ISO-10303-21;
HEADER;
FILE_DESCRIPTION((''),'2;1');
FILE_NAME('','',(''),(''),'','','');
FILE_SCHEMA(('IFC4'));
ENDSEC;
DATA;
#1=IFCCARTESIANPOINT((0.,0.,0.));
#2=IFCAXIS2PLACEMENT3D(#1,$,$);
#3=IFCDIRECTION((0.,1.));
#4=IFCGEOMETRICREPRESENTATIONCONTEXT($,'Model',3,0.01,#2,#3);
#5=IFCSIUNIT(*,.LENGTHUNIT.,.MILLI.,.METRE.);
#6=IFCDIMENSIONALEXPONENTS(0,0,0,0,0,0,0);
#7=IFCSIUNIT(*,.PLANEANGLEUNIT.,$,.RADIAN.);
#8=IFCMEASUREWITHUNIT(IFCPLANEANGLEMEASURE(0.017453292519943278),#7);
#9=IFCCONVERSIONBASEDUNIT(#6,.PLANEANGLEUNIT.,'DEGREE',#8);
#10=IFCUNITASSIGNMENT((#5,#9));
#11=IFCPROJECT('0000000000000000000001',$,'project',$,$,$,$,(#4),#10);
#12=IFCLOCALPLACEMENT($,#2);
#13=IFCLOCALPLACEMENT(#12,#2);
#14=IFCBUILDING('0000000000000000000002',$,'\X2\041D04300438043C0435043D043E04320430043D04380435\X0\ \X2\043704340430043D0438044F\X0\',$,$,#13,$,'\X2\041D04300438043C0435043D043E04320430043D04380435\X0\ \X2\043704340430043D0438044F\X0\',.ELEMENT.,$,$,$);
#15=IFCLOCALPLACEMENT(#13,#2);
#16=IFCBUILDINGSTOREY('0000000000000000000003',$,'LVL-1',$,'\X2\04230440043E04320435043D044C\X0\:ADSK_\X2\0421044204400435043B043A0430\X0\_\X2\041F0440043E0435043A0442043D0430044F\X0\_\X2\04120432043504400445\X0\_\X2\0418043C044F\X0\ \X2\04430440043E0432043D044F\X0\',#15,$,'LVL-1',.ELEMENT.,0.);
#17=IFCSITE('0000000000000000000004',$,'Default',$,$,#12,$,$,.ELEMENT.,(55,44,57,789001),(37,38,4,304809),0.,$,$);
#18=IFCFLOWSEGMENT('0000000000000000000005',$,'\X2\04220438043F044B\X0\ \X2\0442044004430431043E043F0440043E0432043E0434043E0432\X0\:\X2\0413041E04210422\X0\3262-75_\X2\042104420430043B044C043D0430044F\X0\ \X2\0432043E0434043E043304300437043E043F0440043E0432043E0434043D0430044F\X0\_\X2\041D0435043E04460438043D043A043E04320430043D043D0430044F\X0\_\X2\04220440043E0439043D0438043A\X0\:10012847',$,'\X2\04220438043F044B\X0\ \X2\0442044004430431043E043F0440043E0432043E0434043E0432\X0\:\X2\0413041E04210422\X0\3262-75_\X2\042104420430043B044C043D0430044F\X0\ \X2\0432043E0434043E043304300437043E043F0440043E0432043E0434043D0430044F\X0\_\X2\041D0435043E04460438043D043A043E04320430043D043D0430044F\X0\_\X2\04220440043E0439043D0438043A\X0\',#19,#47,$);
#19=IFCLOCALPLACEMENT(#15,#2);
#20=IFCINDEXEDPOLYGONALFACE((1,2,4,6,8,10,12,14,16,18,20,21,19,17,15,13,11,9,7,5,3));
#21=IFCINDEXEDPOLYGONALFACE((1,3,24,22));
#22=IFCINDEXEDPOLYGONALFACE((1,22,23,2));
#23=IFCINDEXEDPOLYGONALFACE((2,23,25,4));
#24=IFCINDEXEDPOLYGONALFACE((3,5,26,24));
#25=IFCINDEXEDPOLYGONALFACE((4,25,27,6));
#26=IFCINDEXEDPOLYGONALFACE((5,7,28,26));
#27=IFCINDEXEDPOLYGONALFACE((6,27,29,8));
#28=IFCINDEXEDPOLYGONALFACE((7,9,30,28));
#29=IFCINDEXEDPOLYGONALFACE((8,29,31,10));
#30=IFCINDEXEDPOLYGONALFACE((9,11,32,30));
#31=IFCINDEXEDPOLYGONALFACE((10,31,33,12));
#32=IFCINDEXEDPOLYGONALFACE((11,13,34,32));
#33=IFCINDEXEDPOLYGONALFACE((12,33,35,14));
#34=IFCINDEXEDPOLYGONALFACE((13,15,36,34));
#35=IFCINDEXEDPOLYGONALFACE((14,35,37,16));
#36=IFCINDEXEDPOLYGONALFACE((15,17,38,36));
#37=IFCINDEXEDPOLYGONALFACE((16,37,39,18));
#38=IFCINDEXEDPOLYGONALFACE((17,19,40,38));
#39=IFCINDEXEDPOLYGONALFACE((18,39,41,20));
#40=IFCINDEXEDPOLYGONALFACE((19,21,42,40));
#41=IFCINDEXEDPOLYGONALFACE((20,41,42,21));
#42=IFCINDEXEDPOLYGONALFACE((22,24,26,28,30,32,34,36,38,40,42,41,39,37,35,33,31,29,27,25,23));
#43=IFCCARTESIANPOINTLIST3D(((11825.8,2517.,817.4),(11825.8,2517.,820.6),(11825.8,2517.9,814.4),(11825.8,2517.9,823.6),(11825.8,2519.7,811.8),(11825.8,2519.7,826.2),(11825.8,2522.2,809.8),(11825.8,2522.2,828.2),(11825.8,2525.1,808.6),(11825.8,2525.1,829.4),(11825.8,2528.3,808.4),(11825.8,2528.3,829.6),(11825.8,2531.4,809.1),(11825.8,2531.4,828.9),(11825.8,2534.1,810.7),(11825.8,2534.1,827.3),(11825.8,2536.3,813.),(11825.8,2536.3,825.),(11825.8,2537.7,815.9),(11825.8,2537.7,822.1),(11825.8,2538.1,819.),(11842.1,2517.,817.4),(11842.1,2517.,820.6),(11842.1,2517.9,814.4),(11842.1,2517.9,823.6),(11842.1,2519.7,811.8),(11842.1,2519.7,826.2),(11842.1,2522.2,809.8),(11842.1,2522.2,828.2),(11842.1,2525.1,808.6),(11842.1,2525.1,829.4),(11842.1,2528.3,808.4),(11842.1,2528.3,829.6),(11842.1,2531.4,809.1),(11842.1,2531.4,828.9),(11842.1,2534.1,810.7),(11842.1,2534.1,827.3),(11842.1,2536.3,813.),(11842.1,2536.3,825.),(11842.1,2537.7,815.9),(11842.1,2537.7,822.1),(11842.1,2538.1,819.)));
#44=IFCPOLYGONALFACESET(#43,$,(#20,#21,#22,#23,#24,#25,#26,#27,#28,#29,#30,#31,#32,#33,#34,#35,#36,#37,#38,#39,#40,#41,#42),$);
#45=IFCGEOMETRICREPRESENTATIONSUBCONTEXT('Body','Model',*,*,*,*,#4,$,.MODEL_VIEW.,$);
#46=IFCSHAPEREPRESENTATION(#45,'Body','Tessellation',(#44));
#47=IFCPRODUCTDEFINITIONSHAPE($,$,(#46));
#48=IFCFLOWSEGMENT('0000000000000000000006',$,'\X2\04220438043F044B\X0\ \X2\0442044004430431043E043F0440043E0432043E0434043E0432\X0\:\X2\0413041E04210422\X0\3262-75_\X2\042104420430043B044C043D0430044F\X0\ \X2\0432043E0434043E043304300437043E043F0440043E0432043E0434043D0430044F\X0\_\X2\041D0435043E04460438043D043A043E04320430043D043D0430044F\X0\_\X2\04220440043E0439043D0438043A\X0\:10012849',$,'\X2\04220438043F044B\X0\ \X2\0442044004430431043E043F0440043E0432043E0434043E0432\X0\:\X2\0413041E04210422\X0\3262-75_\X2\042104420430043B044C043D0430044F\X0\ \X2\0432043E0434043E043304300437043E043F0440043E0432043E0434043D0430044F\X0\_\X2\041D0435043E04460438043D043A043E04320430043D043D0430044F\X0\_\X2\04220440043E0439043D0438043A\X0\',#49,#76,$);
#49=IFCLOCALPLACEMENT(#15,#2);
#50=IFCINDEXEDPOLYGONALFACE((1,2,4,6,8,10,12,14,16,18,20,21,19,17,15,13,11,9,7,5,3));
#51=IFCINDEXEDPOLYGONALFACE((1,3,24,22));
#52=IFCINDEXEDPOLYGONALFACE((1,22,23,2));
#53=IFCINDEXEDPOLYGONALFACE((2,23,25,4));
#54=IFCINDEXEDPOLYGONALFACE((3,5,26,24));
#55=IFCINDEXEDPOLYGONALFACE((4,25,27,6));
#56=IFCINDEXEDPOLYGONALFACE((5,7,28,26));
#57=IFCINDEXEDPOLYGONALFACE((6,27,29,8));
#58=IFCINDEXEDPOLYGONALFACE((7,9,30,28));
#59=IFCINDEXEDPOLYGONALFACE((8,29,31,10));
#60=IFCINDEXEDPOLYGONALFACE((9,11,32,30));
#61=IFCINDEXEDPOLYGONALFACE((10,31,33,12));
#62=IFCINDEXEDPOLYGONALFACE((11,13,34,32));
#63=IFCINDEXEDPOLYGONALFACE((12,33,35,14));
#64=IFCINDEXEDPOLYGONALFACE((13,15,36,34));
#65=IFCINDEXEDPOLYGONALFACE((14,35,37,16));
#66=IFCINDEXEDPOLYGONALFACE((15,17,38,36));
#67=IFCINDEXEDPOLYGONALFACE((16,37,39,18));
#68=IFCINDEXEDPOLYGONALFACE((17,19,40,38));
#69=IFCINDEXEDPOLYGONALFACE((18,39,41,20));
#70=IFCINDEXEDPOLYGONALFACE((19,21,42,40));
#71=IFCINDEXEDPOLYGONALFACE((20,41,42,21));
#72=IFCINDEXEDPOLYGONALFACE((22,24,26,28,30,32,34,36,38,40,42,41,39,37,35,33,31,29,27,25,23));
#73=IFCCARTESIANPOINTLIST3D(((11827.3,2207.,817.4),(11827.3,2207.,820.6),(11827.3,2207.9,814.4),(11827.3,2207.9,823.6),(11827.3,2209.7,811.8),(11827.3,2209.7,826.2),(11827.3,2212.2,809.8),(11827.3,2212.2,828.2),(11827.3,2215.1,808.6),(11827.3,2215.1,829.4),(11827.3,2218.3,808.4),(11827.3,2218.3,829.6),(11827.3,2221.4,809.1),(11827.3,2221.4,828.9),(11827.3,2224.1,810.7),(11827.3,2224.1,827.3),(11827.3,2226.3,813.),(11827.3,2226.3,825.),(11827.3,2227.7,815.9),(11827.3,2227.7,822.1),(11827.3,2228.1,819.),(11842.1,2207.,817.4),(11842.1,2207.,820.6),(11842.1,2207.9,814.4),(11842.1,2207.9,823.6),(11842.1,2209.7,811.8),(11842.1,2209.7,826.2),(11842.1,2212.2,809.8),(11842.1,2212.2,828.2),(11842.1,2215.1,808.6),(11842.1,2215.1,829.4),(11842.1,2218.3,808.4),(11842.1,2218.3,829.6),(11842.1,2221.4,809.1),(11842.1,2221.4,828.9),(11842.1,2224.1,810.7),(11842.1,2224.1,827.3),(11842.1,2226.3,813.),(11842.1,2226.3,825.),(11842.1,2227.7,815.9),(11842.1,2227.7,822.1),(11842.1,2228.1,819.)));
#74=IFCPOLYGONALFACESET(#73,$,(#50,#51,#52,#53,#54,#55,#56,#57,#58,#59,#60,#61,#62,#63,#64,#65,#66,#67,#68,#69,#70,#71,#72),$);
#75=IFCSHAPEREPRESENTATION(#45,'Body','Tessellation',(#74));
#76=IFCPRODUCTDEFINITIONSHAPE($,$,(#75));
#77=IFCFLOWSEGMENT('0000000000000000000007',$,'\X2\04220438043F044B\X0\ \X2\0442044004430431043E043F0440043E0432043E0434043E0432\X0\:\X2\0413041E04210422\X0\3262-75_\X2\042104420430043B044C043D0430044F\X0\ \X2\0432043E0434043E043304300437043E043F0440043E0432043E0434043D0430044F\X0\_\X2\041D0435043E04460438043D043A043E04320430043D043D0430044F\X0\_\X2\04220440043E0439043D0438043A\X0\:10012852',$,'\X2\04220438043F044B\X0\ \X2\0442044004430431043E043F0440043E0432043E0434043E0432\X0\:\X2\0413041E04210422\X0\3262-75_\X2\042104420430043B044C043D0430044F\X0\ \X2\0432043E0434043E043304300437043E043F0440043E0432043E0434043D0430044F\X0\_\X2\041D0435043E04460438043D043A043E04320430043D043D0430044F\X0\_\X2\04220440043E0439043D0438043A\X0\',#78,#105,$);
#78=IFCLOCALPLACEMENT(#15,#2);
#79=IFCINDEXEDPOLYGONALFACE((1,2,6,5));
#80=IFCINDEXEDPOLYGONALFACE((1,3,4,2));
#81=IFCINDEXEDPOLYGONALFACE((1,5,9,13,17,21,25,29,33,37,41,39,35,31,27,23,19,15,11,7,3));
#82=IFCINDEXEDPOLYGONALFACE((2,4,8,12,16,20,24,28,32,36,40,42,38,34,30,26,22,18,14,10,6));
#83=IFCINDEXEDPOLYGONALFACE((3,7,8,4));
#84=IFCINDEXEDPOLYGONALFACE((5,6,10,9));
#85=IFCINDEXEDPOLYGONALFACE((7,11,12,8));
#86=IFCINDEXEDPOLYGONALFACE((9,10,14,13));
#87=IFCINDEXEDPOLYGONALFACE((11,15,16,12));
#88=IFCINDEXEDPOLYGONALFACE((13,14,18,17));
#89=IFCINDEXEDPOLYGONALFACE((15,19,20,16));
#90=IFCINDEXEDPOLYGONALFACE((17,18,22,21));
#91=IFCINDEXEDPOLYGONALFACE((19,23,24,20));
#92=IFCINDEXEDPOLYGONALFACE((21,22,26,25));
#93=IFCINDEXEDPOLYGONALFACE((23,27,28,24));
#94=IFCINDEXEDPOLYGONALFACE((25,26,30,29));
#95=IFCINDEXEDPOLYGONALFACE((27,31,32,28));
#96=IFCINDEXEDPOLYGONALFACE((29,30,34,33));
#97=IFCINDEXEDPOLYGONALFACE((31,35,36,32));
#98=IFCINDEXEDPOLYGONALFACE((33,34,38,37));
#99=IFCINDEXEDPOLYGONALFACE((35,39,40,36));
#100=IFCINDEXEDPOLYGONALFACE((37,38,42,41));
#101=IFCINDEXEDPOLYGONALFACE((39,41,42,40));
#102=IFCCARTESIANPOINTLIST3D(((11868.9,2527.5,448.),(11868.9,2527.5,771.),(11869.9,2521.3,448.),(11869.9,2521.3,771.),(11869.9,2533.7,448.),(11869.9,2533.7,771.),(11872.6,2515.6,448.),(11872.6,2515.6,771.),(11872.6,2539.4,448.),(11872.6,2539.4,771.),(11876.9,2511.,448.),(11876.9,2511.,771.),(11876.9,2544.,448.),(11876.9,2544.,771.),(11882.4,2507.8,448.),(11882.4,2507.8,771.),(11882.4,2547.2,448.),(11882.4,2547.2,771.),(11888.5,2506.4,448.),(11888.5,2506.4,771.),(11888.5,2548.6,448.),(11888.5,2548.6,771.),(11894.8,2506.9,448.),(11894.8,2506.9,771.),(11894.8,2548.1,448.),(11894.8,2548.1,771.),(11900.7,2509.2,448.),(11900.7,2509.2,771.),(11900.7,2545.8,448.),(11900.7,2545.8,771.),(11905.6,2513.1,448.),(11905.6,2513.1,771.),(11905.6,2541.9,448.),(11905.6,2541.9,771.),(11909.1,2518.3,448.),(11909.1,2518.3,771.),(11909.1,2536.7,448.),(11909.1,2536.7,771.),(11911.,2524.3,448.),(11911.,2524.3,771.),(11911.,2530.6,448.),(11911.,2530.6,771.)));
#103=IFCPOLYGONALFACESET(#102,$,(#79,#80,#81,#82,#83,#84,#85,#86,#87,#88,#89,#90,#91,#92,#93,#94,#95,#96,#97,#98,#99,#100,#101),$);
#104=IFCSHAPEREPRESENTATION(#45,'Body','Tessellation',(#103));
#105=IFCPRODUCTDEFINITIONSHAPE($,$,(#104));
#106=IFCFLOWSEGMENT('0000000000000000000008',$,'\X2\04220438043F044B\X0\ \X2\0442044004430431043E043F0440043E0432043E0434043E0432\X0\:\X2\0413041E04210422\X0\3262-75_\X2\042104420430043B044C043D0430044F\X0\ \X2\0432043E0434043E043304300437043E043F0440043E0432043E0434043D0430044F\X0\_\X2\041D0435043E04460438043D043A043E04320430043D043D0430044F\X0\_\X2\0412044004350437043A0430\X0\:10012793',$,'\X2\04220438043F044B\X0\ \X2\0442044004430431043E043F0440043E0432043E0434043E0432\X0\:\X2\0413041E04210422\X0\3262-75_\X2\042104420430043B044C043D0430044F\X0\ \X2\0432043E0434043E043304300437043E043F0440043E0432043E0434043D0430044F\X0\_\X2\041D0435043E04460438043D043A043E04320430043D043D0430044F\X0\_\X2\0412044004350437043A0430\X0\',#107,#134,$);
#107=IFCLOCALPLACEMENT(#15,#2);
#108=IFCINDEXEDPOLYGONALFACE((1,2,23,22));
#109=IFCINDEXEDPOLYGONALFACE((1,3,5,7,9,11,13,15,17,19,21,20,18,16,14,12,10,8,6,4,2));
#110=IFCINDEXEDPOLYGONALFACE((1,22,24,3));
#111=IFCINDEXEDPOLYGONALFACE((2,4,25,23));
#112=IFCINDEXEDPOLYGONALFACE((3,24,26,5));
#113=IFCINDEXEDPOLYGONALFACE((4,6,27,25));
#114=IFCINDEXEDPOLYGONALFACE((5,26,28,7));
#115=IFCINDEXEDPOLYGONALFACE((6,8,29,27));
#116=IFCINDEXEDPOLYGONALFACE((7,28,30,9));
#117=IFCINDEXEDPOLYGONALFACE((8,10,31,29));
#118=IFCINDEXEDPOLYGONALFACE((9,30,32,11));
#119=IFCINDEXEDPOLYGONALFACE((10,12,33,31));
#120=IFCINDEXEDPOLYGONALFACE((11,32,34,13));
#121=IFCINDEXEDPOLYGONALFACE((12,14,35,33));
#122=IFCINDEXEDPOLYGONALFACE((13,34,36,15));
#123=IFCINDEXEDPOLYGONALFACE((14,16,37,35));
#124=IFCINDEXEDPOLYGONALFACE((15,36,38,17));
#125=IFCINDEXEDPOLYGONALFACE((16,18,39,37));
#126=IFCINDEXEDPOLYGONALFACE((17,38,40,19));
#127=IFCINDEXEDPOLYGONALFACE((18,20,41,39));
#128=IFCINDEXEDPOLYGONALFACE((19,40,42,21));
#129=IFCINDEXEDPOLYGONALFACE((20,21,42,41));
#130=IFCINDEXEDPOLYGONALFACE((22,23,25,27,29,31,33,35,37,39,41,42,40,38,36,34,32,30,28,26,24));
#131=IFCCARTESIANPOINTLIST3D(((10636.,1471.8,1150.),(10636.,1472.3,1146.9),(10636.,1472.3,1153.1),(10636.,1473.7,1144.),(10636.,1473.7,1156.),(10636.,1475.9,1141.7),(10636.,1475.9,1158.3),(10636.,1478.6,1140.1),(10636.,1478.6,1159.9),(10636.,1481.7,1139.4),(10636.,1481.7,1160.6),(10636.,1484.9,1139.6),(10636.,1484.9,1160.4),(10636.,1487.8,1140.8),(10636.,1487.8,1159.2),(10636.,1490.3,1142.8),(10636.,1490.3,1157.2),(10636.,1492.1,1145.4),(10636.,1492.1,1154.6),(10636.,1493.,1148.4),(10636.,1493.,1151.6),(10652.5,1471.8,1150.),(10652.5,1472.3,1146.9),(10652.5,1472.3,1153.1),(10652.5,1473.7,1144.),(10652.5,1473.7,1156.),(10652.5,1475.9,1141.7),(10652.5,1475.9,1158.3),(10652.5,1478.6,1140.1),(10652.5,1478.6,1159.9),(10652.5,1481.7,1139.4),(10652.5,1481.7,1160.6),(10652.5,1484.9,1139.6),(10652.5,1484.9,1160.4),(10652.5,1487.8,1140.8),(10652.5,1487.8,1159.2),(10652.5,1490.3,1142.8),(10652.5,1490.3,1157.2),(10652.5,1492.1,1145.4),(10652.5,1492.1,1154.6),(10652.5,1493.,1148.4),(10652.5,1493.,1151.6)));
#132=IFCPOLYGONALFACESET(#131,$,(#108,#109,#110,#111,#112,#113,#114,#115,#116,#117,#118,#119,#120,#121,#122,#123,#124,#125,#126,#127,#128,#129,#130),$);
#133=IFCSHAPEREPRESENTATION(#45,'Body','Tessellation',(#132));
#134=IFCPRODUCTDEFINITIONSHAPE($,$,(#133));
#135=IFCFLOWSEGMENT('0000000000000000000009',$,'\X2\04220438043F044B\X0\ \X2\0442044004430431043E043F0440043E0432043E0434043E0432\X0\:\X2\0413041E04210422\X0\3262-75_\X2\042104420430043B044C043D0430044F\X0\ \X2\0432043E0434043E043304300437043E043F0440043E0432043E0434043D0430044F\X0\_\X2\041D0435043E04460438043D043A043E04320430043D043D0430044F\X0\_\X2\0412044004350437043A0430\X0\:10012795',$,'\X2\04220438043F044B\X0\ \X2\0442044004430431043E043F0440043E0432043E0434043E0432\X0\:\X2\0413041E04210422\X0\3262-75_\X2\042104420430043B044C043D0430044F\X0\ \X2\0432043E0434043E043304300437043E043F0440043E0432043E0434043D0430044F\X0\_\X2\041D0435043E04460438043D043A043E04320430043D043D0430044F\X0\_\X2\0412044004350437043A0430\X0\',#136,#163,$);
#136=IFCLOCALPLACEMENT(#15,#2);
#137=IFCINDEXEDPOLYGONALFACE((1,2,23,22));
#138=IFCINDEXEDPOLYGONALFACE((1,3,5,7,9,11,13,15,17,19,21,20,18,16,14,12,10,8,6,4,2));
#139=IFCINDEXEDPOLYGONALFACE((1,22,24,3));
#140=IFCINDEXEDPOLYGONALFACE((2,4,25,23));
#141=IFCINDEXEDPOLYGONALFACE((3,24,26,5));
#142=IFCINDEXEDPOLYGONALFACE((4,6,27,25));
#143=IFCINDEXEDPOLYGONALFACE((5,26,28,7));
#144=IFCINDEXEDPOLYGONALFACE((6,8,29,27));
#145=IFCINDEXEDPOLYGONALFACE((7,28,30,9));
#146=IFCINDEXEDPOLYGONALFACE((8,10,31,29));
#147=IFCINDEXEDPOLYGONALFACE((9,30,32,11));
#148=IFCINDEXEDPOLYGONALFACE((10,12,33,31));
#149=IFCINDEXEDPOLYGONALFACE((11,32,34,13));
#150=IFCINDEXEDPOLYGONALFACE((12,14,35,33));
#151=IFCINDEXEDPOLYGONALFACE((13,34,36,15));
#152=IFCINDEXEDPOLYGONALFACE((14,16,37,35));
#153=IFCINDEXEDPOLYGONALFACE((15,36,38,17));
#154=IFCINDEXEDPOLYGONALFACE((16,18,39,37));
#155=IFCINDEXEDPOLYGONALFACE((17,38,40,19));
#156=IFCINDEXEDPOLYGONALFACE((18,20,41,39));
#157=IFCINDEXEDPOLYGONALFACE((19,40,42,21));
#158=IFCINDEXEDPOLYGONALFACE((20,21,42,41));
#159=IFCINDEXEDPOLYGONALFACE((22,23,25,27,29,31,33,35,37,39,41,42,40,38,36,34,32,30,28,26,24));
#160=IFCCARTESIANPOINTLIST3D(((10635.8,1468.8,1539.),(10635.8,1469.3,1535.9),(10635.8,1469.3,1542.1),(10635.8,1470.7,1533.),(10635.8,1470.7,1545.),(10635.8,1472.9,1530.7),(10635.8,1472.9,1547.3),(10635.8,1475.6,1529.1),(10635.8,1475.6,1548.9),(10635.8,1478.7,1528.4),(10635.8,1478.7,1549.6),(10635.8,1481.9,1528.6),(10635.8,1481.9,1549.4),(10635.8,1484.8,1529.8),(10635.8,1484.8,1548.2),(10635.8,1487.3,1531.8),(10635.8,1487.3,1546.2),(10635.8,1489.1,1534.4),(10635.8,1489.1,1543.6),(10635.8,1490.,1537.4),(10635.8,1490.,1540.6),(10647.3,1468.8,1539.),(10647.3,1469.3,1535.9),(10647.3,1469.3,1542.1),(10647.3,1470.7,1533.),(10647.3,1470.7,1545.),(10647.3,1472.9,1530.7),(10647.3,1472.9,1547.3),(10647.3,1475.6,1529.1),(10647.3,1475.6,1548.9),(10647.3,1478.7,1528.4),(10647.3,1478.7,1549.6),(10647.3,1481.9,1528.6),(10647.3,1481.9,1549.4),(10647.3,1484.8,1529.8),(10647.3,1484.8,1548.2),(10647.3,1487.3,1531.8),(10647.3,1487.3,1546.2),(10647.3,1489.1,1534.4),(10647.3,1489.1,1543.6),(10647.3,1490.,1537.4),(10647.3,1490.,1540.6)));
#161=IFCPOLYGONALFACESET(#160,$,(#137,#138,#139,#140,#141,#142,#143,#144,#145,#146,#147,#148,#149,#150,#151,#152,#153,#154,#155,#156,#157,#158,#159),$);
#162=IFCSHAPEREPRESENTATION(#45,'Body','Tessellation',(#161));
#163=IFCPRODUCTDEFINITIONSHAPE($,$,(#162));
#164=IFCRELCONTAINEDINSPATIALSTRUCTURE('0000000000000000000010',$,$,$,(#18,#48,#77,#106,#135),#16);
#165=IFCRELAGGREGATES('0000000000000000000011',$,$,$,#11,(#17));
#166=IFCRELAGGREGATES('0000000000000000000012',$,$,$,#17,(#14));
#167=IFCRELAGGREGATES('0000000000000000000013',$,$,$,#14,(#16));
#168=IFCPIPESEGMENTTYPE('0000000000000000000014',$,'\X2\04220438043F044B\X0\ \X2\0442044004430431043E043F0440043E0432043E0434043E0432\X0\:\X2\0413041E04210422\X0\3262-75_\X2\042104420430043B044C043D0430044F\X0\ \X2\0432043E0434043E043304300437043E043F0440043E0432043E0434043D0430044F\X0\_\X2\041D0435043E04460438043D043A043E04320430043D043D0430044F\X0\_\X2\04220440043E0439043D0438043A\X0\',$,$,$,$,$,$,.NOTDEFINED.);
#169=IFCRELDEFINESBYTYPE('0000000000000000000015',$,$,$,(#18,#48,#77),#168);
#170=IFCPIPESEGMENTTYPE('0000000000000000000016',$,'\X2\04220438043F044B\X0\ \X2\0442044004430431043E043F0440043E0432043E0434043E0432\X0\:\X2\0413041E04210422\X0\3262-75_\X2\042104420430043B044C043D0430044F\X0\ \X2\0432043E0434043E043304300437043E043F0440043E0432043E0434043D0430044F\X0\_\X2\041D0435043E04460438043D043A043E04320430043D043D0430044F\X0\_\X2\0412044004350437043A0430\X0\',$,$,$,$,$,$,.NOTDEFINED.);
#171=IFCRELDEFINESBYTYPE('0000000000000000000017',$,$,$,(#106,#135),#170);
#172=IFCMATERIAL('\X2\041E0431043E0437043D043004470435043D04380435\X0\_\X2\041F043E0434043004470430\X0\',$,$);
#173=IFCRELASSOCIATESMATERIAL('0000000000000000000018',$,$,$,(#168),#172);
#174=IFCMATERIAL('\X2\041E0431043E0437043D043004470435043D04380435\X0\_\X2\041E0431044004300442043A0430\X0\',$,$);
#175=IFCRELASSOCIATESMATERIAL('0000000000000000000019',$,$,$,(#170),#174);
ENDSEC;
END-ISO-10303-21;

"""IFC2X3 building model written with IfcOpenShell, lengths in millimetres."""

from ifc_helpers import new_model, entity, si_unit, converted_unit, direction, frame, origin, origin_2d_with_axis, place, context, subcontext, project, spatial, circle, extrude, material, type_object, element, save


model = new_model("IFC2X3")

# Units and contexts
model_context = context("Model", 3, precision=0.01, world=origin(), true_north=direction((0.0, 1.0)))
body_context = subcontext(model_context, "Body", "Model", "MODEL_VIEW")
ifc_project = project(units=[si_unit("LENGTHUNIT", "METRE", prefix="MILLI"), converted_unit("PLANEANGLEUNIT", "DEGREE", entity("IfcPlaneAngleMeasure", 0.017453292519943278), si_unit("PLANEANGLEUNIT", "RADIAN"), dimensions=[0, 0, 0, 0, 0, 0, 0])], contexts=[model_context])

# Site, building, storey
site_placement = place(None, origin())
site = spatial("IfcSite", under=ifc_project, at=site_placement, Name="Default", CompositionType="ELEMENT", RefLatitude=(55, 44, 57, 789001), RefLongitude=(37, 38, 4, 304809), RefElevation=0.0)
building_placement = place(site_placement, origin())
building = spatial("IfcBuilding", under=site, at=building_placement, Name="Наименование здания", LongName="Наименование здания", CompositionType="ELEMENT")
storey_placement = place(building_placement, origin())
storey = spatial("IfcBuildingStorey", under=building, at=storey_placement, Name="LVL-1", ObjectType="Уровень:ADSK_Стрелка_Проектная_Вверх_Имя уровня", LongName="LVL-1", CompositionType="ELEMENT", Elevation=0.0)

# Flow segments
ifc_material_1 = material(Name="Обозначение_Подача")
pipe_segment_type_1 = type_object("IfcPipeSegmentType", Name="Типы трубопроводов:ГОСТ3262-75_Стальная водогазопроводная_Неоцинкованная_Тройник", PredefinedType="NOTDEFINED", material=ifc_material_1)
flow_segment_1_placement = place(storey_placement, origin())
element("IfcFlowSegment", 1, at=flow_segment_1_placement, inside=storey, type_object=pipe_segment_type_1, Name="Типы трубопроводов:ГОСТ3262-75_Стальная водогазопроводная_Неоцинкованная_Тройник:10012847", ObjectType="Типы трубопроводов:ГОСТ3262-75_Стальная водогазопроводная_Неоцинкованная_Тройник", context=body_context, shape_type="SweptSolid", body=[
    extrude(circle(Radius=10.7, at=origin_2d_with_axis()), frame((11825.8, 2527.5, 819.0), z_axis=(1.0, 0.0, 0.0), x_axis=(0.0, 1.0, 0.0)), (0.0, 0.0, 1.0), 16.3),
])
flow_segment_2_placement = place(storey_placement, origin())
element("IfcFlowSegment", 2, at=flow_segment_2_placement, inside=storey, type_object=pipe_segment_type_1, Name="Типы трубопроводов:ГОСТ3262-75_Стальная водогазопроводная_Неоцинкованная_Тройник:10012849", ObjectType="Типы трубопроводов:ГОСТ3262-75_Стальная водогазопроводная_Неоцинкованная_Тройник", context=body_context, shape_type="SweptSolid", body=[
    extrude(circle(Radius=10.7, at=origin_2d_with_axis()), frame((11827.3, 2217.5, 819.0), z_axis=(1.0, 0.0, 0.0), x_axis=(0.0, 1.0, 0.0)), (0.0, 0.0, 1.0), 14.8),
])
flow_segment_3_placement = place(storey_placement, origin())
element("IfcFlowSegment", 3, at=flow_segment_3_placement, inside=storey, type_object=pipe_segment_type_1, Name="Типы трубопроводов:ГОСТ3262-75_Стальная водогазопроводная_Неоцинкованная_Тройник:10012852", ObjectType="Типы трубопроводов:ГОСТ3262-75_Стальная водогазопроводная_Неоцинкованная_Тройник", context=body_context, shape_type="SweptSolid", body=[
    extrude(circle(Radius=21.1, at=origin_2d_with_axis()), frame((11890.1, 2527.5, 448.0), z_axis=(0.0, 0.0, 1.0), x_axis=(-1.0, 0.0, 0.0)), (0.0, 0.0, 1.0), 323.0),
])
ifc_material_2 = material(Name="Обозначение_Обратка")
pipe_segment_type_2 = type_object("IfcPipeSegmentType", Name="Типы трубопроводов:ГОСТ3262-75_Стальная водогазопроводная_Неоцинкованная_Врезка", PredefinedType="NOTDEFINED", material=ifc_material_2)
flow_segment_4_placement = place(storey_placement, origin())
element("IfcFlowSegment", 4, at=flow_segment_4_placement, inside=storey, type_object=pipe_segment_type_2, Name="Типы трубопроводов:ГОСТ3262-75_Стальная водогазопроводная_Неоцинкованная_Врезка:10012793", ObjectType="Типы трубопроводов:ГОСТ3262-75_Стальная водогазопроводная_Неоцинкованная_Врезка", context=body_context, shape_type="SweptSolid", body=[
    extrude(circle(Radius=10.7, at=origin_2d_with_axis()), frame((10636.0, 1482.5, 1150.0), z_axis=(1.0, 0.0, 0.0), x_axis=(0.0, -1.0, 0.0)), (0.0, 0.0, 1.0), 16.5),
])
flow_segment_5_placement = place(storey_placement, origin())
element("IfcFlowSegment", 5, at=flow_segment_5_placement, inside=storey, type_object=pipe_segment_type_2, Name="Типы трубопроводов:ГОСТ3262-75_Стальная водогазопроводная_Неоцинкованная_Врезка:10012795", ObjectType="Типы трубопроводов:ГОСТ3262-75_Стальная водогазопроводная_Неоцинкованная_Врезка", context=body_context, shape_type="SweptSolid", body=[
    extrude(circle(Radius=10.7, at=origin_2d_with_axis()), frame((10635.8, 1479.5, 1539.0), z_axis=(1.0, 0.0, 0.0), x_axis=(0.0, -1.0, 0.0)), (0.0, 0.0, 1.0), 11.5),
])

save(model, "model.ifc")
